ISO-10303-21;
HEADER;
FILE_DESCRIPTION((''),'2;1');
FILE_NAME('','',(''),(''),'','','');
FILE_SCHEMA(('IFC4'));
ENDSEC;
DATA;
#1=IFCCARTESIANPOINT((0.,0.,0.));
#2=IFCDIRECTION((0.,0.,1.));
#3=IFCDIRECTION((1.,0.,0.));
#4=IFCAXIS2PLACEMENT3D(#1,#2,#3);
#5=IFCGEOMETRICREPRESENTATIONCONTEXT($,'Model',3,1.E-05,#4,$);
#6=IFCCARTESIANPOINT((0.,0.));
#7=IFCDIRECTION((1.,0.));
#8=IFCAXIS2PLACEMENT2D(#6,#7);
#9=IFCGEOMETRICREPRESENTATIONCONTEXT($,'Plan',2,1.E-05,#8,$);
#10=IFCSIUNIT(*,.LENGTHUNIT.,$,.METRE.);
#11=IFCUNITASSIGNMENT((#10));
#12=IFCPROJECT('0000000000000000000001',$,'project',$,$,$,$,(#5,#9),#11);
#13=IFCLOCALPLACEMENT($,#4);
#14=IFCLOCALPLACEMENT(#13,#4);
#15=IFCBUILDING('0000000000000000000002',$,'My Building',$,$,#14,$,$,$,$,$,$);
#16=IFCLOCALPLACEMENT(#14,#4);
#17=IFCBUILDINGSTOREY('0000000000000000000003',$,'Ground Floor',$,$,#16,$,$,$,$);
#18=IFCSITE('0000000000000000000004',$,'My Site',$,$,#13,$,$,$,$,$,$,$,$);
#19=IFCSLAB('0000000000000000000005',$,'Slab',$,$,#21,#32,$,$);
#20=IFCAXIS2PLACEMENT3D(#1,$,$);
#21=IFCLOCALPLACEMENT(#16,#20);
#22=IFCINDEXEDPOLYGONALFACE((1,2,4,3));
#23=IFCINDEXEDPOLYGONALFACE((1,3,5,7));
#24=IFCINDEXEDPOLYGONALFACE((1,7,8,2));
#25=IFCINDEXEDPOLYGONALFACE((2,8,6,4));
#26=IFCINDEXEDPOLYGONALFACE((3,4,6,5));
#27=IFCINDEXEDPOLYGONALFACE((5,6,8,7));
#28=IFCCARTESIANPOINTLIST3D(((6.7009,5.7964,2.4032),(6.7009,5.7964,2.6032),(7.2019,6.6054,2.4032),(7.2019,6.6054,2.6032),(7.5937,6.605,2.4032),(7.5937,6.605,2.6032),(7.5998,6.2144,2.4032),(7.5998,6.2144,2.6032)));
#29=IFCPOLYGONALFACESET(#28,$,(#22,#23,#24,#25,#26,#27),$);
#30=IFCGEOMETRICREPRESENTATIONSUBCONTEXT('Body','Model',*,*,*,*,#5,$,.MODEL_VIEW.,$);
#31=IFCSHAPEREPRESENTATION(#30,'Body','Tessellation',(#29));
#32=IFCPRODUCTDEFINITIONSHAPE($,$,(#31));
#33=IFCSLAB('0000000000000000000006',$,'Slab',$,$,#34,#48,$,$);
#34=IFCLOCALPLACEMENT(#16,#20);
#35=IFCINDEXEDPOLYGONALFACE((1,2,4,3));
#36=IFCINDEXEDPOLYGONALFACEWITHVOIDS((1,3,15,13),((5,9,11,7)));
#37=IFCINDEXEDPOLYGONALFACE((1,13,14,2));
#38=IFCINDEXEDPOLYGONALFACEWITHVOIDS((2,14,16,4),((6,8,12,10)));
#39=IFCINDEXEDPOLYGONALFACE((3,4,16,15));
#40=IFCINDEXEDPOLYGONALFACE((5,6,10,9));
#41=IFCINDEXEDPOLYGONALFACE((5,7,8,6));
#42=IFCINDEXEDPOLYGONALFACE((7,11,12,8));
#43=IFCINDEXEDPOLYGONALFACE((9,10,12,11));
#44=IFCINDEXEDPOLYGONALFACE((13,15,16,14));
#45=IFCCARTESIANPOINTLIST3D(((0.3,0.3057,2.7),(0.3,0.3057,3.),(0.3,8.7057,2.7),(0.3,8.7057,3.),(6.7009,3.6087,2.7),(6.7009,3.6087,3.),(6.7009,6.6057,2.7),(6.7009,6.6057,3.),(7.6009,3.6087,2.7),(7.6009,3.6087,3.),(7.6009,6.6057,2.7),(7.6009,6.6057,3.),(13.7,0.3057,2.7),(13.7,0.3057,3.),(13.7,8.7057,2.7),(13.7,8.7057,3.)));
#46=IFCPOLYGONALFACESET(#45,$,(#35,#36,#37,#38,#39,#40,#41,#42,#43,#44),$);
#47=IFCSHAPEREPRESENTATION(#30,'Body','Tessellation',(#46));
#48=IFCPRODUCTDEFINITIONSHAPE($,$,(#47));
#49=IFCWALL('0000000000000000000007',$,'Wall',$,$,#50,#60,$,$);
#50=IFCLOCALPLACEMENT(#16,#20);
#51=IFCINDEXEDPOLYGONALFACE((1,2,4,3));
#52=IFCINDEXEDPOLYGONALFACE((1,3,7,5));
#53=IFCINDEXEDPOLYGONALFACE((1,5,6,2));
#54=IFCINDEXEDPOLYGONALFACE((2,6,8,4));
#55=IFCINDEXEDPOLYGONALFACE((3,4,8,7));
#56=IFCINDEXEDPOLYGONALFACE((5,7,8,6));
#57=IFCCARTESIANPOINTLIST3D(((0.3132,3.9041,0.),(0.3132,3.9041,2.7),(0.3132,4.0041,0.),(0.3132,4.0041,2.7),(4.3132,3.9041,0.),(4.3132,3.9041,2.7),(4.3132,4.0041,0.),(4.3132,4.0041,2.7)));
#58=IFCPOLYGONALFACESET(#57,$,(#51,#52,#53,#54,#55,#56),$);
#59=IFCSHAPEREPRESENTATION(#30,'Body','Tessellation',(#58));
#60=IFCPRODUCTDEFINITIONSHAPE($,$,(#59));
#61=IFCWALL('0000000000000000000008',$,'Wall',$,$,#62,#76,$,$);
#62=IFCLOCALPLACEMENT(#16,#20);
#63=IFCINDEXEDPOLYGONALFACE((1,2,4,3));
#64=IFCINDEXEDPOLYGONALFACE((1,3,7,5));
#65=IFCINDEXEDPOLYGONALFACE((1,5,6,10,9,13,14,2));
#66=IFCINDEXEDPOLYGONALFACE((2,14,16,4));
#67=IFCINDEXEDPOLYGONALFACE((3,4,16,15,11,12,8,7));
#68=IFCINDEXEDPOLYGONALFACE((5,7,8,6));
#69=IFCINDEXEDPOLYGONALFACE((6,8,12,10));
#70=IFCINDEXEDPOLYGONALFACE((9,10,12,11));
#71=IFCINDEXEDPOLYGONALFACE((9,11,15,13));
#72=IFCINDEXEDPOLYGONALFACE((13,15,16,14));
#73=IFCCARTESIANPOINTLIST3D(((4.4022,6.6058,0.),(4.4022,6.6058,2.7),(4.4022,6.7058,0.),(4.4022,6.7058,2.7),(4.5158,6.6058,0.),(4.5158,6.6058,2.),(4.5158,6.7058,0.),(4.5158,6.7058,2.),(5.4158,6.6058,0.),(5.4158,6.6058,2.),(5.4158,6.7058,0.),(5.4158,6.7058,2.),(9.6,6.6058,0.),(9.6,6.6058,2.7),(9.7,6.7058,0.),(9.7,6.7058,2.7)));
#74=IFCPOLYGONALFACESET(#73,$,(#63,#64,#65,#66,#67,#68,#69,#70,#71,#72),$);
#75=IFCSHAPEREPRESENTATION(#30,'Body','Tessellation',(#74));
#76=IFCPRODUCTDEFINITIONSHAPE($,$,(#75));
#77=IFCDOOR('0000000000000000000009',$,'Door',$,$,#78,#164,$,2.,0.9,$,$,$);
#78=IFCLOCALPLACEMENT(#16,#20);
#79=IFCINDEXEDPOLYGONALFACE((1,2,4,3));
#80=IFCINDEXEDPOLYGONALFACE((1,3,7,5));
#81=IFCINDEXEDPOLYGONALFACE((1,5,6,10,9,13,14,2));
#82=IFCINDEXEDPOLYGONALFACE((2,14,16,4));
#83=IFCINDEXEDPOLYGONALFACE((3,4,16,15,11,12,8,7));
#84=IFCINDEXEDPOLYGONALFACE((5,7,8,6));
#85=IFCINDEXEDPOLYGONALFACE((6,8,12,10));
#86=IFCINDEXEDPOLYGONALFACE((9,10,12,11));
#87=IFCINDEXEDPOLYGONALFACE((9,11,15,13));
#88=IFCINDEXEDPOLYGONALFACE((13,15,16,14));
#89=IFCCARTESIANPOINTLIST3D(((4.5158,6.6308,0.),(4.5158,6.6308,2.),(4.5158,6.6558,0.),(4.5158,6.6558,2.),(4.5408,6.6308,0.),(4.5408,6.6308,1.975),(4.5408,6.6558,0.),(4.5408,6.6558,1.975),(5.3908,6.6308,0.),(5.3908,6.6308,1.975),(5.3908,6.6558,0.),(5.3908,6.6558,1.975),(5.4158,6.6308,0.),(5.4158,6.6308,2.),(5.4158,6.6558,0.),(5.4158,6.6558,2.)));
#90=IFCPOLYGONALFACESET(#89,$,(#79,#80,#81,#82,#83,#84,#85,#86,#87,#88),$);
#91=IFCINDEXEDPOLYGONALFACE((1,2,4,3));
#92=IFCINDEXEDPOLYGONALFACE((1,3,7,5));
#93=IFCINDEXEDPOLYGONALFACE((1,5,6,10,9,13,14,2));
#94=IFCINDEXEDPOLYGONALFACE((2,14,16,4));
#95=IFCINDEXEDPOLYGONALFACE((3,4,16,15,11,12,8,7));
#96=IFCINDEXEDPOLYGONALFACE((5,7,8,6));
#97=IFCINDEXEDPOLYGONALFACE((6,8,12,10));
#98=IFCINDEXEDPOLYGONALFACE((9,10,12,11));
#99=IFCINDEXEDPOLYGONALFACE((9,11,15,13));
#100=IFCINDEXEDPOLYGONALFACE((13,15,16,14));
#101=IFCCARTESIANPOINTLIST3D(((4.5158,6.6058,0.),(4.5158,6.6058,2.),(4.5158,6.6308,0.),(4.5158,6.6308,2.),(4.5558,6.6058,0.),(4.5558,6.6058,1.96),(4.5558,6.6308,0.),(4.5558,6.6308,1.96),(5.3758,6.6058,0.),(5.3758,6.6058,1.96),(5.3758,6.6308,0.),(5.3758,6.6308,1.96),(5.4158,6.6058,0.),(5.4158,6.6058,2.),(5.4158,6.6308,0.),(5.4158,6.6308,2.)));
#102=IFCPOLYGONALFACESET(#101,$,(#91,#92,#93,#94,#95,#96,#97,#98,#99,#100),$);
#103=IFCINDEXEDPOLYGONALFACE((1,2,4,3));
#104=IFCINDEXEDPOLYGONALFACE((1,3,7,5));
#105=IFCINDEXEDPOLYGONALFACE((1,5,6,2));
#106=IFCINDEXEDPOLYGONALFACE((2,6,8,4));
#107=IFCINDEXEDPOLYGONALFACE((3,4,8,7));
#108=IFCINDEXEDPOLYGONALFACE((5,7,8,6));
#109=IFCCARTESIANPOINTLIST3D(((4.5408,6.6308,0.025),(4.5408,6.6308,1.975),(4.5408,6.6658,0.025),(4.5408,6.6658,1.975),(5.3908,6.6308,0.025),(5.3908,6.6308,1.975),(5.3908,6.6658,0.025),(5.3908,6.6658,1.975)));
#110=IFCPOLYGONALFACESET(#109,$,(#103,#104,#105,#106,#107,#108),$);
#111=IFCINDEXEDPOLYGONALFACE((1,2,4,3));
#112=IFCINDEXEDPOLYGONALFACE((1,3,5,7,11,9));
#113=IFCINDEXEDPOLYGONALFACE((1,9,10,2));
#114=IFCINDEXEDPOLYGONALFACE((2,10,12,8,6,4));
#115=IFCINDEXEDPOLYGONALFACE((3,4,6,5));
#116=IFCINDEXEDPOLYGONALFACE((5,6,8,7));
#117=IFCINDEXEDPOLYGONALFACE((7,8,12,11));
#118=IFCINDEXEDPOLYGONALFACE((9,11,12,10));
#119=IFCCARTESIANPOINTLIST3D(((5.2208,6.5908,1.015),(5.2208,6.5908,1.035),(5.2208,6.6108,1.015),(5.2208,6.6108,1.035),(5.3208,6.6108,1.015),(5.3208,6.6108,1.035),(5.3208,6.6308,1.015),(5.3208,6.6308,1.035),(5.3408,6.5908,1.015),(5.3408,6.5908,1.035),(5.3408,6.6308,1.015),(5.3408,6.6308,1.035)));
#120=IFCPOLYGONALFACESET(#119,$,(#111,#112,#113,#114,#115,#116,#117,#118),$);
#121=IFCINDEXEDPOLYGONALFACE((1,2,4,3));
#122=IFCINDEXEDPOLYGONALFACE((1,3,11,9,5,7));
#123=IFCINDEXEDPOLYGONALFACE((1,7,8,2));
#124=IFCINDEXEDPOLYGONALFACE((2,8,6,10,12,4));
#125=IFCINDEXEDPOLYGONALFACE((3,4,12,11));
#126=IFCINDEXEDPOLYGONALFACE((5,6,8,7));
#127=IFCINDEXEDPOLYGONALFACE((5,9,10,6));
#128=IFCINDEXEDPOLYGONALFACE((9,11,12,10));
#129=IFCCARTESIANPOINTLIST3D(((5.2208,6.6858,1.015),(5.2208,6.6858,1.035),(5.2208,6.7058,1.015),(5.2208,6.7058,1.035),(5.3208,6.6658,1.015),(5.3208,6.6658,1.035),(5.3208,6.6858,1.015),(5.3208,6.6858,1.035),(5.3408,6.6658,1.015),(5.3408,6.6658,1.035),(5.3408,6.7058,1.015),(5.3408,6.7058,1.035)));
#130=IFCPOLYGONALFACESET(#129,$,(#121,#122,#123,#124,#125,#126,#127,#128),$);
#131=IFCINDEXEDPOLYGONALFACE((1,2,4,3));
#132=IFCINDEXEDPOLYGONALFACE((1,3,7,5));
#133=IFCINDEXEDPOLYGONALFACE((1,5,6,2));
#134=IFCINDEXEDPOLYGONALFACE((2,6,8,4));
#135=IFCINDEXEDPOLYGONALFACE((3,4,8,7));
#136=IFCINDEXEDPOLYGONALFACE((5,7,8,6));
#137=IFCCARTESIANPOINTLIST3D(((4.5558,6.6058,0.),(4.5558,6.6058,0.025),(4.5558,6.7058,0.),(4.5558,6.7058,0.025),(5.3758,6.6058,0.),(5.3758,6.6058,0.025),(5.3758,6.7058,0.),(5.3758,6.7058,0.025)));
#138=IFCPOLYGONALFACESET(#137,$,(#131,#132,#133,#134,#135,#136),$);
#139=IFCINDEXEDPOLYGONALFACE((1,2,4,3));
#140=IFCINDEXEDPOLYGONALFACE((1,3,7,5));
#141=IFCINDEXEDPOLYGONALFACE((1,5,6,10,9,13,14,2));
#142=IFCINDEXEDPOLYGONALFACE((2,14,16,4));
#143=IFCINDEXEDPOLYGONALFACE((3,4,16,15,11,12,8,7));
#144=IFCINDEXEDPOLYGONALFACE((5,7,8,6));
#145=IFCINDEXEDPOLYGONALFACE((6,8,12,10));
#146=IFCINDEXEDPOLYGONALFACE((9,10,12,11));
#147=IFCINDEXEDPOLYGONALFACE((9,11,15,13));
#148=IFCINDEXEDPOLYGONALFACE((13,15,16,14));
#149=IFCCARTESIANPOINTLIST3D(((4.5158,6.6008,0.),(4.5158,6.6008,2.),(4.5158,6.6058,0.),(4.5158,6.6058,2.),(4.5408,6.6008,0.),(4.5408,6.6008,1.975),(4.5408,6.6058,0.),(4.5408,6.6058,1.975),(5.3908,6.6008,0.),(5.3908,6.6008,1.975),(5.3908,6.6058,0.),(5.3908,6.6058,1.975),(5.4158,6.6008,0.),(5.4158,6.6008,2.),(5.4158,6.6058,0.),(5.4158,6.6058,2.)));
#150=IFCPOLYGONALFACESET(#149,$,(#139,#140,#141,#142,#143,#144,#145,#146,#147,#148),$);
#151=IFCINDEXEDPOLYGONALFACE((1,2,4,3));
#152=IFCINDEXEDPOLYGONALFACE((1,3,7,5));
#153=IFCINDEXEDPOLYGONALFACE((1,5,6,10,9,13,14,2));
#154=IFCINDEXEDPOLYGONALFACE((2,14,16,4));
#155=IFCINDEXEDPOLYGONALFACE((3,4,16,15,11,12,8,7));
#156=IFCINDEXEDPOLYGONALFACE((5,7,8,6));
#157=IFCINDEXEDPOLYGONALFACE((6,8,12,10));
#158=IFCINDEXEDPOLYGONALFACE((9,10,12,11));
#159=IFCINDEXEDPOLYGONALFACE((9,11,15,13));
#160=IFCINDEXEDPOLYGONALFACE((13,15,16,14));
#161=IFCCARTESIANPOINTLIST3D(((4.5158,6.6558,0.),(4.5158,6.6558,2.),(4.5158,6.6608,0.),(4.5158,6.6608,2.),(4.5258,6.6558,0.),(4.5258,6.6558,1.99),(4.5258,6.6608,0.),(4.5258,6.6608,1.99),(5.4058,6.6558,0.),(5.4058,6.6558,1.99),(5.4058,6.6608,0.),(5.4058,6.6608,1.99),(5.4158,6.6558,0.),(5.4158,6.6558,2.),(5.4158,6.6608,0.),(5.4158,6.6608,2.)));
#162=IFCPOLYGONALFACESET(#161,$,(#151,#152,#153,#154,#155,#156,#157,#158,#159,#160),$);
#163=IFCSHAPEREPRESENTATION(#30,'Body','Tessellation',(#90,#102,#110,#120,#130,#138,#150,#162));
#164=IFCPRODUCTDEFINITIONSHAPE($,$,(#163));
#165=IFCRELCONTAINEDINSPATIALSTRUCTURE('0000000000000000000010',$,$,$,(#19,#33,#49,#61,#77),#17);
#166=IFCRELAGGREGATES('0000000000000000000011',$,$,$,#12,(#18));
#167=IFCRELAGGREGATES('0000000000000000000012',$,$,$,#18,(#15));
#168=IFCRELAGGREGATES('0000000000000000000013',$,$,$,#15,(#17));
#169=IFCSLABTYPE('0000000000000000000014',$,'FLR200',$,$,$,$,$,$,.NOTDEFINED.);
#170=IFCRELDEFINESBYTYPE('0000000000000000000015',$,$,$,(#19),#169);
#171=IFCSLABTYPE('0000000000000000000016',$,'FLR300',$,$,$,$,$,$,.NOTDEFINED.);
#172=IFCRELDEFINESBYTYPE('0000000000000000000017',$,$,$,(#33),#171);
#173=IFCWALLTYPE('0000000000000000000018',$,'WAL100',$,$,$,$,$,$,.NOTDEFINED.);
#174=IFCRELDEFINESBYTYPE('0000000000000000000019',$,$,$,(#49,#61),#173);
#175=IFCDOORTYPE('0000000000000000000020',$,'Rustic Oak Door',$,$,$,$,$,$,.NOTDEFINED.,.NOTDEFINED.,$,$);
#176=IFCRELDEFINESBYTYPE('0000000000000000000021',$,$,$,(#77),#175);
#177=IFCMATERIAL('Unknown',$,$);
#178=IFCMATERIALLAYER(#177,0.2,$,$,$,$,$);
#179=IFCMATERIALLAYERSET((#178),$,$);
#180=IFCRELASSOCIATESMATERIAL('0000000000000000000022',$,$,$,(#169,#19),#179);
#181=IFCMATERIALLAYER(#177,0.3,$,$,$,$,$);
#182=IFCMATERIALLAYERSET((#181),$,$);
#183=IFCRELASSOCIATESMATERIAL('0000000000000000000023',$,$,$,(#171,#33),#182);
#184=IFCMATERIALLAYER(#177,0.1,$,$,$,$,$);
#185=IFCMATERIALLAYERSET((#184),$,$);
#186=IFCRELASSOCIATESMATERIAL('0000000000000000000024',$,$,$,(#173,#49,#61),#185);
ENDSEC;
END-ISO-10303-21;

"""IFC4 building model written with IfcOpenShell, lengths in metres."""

from ifc_helpers import new_model, entity, si_unit, frame, origin_with_axes, origin_2d_with_axis, place, context, subcontext, project, spatial, line, indexed_curve, outline, extrude, shape, source, transform, mapped, material, layer, layer_set, layer_usage, type_object, type_shapes, element, fill, save


model = new_model("IFC4")

# Units and contexts
model_context = context("Model", 3, precision=1e-05, world=origin_with_axes())
plan_context = context("Plan", 2, precision=1e-05, world=origin_2d_with_axis())
body_context_1 = subcontext(model_context, "Body", "Model", "MODEL_VIEW")
body_context_2 = subcontext(plan_context, "Body", "Plan", "PLAN_VIEW")
ifc_project = project(units=[si_unit("LENGTHUNIT", "METRE")], contexts=[model_context, plan_context])

# Site, building, storey
site_placement = place(None, origin_with_axes())
site = spatial("IfcSite", under=ifc_project, at=site_placement, Name="My Site")
building_placement = place(site_placement, origin_with_axes())
building = spatial("IfcBuilding", under=site, at=building_placement, Name="My Building")
storey_placement = place(building_placement, origin_with_axes())
storey = spatial("IfcBuildingStorey", under=building, at=storey_placement, Name="Ground Floor")

# Slabs
ifc_material = material(Name="Unknown")
ifc_layer_1 = layer(ifc_material, 0.2)
ifc_layer_set_1 = layer_set([ifc_layer_1])
slab_type_1 = type_object("IfcSlabType", Name="FLR200", PredefinedType="NOTDEFINED", material=ifc_layer_set_1)
ifc_layer_usage_1 = layer_usage(ifc_layer_set_1, "AXIS3", "POSITIVE", -0.3)
slab_1_placement = place(storey_placement, frame((6.7009, 5.7964, 2.7032), z_axis=(0.0, 0.0, 1.0), x_axis=(1.0, 0.0, 0.0)))
element("IfcSlab", 1, at=slab_1_placement, inside=storey, type_object=slab_type_1, material=ifc_layer_usage_1, Name="Slab", context=body_context_1, shape_type="SweptSolid", body=[
    extrude(outline(indexed_curve([(0.0, 0.0), (0.899, 0.418), (0.8928, 0.8086), (0.501, 0.809), (0.0, 0.0)])), frame((0.0, 0.0, -0.3), z_axis=(0.0, 0.0, 1.0), x_axis=(1.0, 0.0, 0.0)), (0.0, 0.0, 1.0), 0.2),
])
ifc_layer_2 = layer(ifc_material, 0.3)
ifc_layer_set_2 = layer_set([ifc_layer_2])
ifc_layer_usage_2 = layer_usage(ifc_layer_set_2, "AXIS3", "POSITIVE", -0.2)
slab_type_2 = type_object("IfcSlabType", Name="FLR300", PredefinedType="NOTDEFINED", material=ifc_layer_set_2)
slab_2_placement = place(storey_placement, frame((0.3, 8.7057, 2.9), z_axis=(0.0, 0.0, 1.0), x_axis=(1.0, 0.0, 0.0)))
element("IfcSlab", 2, at=slab_2_placement, inside=storey, type_object=slab_type_2, material=ifc_layer_usage_2, Name="Slab", context=body_context_1, shape_type="SweptSolid", body=[
    extrude(outline(indexed_curve([(0.0, 0.0), (13.4, 0.0), (13.4, -8.4), (0.0, -8.4), (0.0, 0.0)]), holes=[indexed_curve([(6.4009, -5.0969), (7.3009, -5.0969), (7.3009, -2.1), (6.4009, -2.1), (6.4009, -5.0969)])]), frame((0.0, 0.0, -0.2), z_axis=(0.0, 0.0, 1.0), x_axis=(1.0, 0.0, 0.0)), (0.0, 0.0, 1.0), 0.3),
])

# Shared definitions
ifc_layer_3 = layer(ifc_material, 0.1)
ifc_layer_set_3 = layer_set([ifc_layer_3])
wall_type = type_object("IfcWallType", Name="WAL100", PredefinedType="NOTDEFINED", material=ifc_layer_set_3)

# Wall
ifc_layer_usage_3 = layer_usage(ifc_layer_set_3, "AXIS2", "POSITIVE", 0.0)
wall_1_placement = place(storey_placement, frame((4.3132, 4.0041, 0.0), z_axis=(0.0, 0.0, 1.0), x_axis=(-1.0, 0.0, 0.0)))
element("IfcWall", 3, at=wall_1_placement, inside=storey, type_object=wall_type, material=ifc_layer_usage_3, Name="Wall", context=body_context_1, shape_type="SweptSolid", body=[
    extrude(outline(indexed_curve([(0.0, 0.0), (0.0, 0.1), (4.0, 0.1), (4.0, 0.0)], segments=[line(1, 2, 3, 4, 1)])), origin_with_axes(), (0.0, 0.0, 1.0), 2.7),
])

# Wall, opening, door
ifc_layer_usage_4 = layer_usage(ifc_layer_set_3, "AXIS2", "POSITIVE", 0.0)
wall_2_placement = place(storey_placement, frame((4.4022, 6.6058, 0.0), z_axis=(0.0, 0.0, 1.0), x_axis=(1.0, 0.0, 0.0)))
wall_2 = element("IfcWall", 4, at=wall_2_placement, inside=storey, type_object=wall_type, material=ifc_layer_usage_4, Name="Wall", context=body_context_1, shape_type="SweptSolid", body=[
    extrude(outline(indexed_curve([(0.0, 0.0), (0.0, 0.1), (5.2978, 0.1), (5.1978, 0.0)], segments=[line(1, 2, 3, 4, 1)])), origin_with_axes(), (0.0, 0.0, 1.0), 2.7),
])
shared_shape_1 = source(origin_with_axes(), body_context_1, "Body", "SweptSolid", [
    extrude(outline(indexed_curve([(0.0, 0.0), (0.9, 0.0), (0.9, 2.0), (0.0, 2.0)], segments=[line(1, 2, 3, 4, 1)])), frame((0.0, -0.6, 0.0), z_axis=(0.0, -1.0, 0.0), x_axis=(1.0, 0.0, 0.0)), (0.0, 0.0, -1.0), 1.2),
])
opening_1_placement = place(wall_2_placement, frame((0.1136, 0.0, 0.0), z_axis=(0.0, 0.0, 1.0), x_axis=(1.0, 0.0, 0.0)))
opening_1 = element("IfcOpeningElement", 5, at=opening_1_placement, cuts=wall_2, PredefinedType="OPENING", context=body_context_1, shape_type="MappedRepresentation", body=[
    mapped(shared_shape_1, transform((0.0, 0.0, 0.0), x_axis=(1.0, 0.0, 0.0), y_axis=(0.0, 1.0, 0.0), z_axis=(0.0, 0.0, 1.0), scale=1.0)),
])
door_type_1 = type_object("IfcDoorType", Name="Rustic Oak Door", OperationType="NOTDEFINED", PredefinedType="NOTDEFINED")
shared_shape_2 = source(origin_with_axes(), body_context_1, "Body", "SweptSolid", [
    extrude(outline(indexed_curve([(0.0, 0.0), (0.0, 2.0), (0.9, 2.0), (0.9, 0.0), (0.875, 0.0), (0.875, 1.975), (0.025, 1.975), (0.025, 0.0)], segments=[line(1, 2, 3, 4, 5, 6, 7, 8, 1)])), frame((0.0, 0.025, 0.0), z_axis=(0.0, -1.0, 0.0), x_axis=(1.0, 0.0, 0.0)), (0.0, 0.0, -1.0), 0.025),
    extrude(outline(indexed_curve([(0.0, 0.0), (0.0, 2.0), (0.9, 2.0), (0.9, 0.0), (0.86, 0.0), (0.86, 1.96), (0.04, 1.96), (0.04, 0.0)], segments=[line(1, 2, 3, 4, 5, 6, 7, 8, 1)])), frame((0.0, 0.0, 0.0), z_axis=(0.0, -1.0, 0.0), x_axis=(1.0, 0.0, 0.0)), (0.0, 0.0, -1.0), 0.025),
    extrude(outline(indexed_curve([(0.0, 0.0), (0.85, 0.0), (0.85, 0.035), (0.0, 0.035)], segments=[line(1, 2, 3, 4, 1)])), frame((0.025, 0.025, 0.025), z_axis=(0.0, 0.0, 1.0), x_axis=(1.0, 0.0, 0.0)), (0.0, 0.0, 1.0), 1.95),
    extrude(outline(indexed_curve([(0.0, 0.0), (0.0, -0.04), (-0.12, -0.04), (-0.12, -0.02), (-0.02, -0.02), (-0.02, 0.0)], segments=[line(1, 2, 3, 4, 5, 6, 1)])), frame((0.825, 0.025, 1.015), z_axis=(0.0, 0.0, 1.0), x_axis=(1.0, 0.0, 0.0)), (0.0, 0.0, 1.0), 0.02),
    extrude(outline(indexed_curve([(0.0, 0.0), (0.0, 0.04), (-0.12, 0.04), (-0.12, 0.02), (-0.02, 0.02), (-0.02, 0.0)], segments=[line(1, 2, 3, 4, 5, 6, 1)])), frame((0.825, 0.06, 1.015), z_axis=(0.0, 0.0, 1.0), x_axis=(1.0, 0.0, 0.0)), (0.0, 0.0, 1.0), 0.02),
    extrude(outline(indexed_curve([(0.0, 0.0), (0.82, 0.0), (0.82, 0.1), (0.0, 0.1)], segments=[line(1, 2, 3, 4, 1)])), frame((0.04, 0.0, 0.0), z_axis=(0.0, 0.0, 1.0), x_axis=(1.0, 0.0, 0.0)), (0.0, 0.0, 1.0), 0.025),
    extrude(outline(indexed_curve([(0.0, 0.0), (0.0, 2.0), (0.9, 2.0), (0.9, 0.0), (0.875, 0.0), (0.875, 1.975), (0.025, 1.975), (0.025, 0.0)], segments=[line(1, 2, 3, 4, 5, 6, 7, 8, 1)])), frame((0.0, -0.005, 0.0), z_axis=(0.0, -1.0, 0.0), x_axis=(1.0, 0.0, 0.0)), (0.0, 0.0, -1.0), 0.005),
    extrude(outline(indexed_curve([(0.0, 0.0), (0.0, 2.0), (0.9, 2.0), (0.9, 0.0), (0.89, 0.0), (0.89, 1.99), (0.01, 1.99), (0.01, 0.0)], segments=[line(1, 2, 3, 4, 5, 6, 7, 8, 1)])), frame((0.0, 0.05, 0.0), z_axis=(0.0, -1.0, 0.0), x_axis=(1.0, 0.0, 0.0)), (0.0, 0.0, -1.0), 0.005),
])
shared_shape_3 = source(origin_with_axes(), body_context_2, "Body", "Curve2D", [
    entity("IfcIndexedPolyCurve", entity("IfcCartesianPointList2D", [[0.0, 0.0], [0.0, 0.05], [0.025, 0.05], [0.025, 0.025], [0.04, 0.025], [0.04, 0.0]]), [entity("IfcLineIndex", [1, 2, 3, 4, 5, 6, 1])]),
    entity("IfcIndexedPolyCurve", entity("IfcCartesianPointList2D", [[0.9, 0.0], [0.9, 0.05], [0.875, 0.05], [0.875, 0.025], [0.86, 0.025], [0.86, 0.0]]), [entity("IfcLineIndex", [1, 2, 3, 4, 5, 6, 1])]),
    entity("IfcTrimmedCurve", entity("IfcEllipse", entity("IfcAxis2Placement2D", entity("IfcCartesianPoint", [0.06, 0.05]), entity("IfcDirection", [1.0, 0.0])), 0.815, 0.85), [entity("IfcCartesianPoint", [0.875, 0.05])], [entity("IfcCartesianPoint", [0.06, 0.9])], True, "CARTESIAN"),
    entity("IfcIndexedPolyCurve", entity("IfcCartesianPointList2D", [[0.025, 0.05], [0.06, 0.05], [0.06, 0.9], [0.025, 0.9]]), [entity("IfcLineIndex", [1, 2, 3, 4, 1])]),
])
type_shapes(door_type_1, [shared_shape_2, shared_shape_3])
door_1_placement = place(opening_1_placement, frame((0.0, 0.0, 0.0), z_axis=(0.0, 0.0, 1.0), x_axis=(1.0, 0.0, 0.0)))
door_1 = element("IfcDoor", 6, at=door_1_placement, inside=storey, type_object=door_type_1, Name="Door", OverallHeight=2.0, OverallWidth=0.9, shapes=[
    shape(body_context_1, "Body", "MappedRepresentation", [mapped(shared_shape_2, transform((0.0, 0.0, 0.0), x_axis=(1.0, 0.0, 0.0), y_axis=(0.0, 1.0, 0.0), z_axis=(0.0, 0.0, 1.0), scale=1.0))]),
    shape(body_context_2, "Body", "MappedRepresentation", [mapped(shared_shape_3, transform((0.0, 0.0, 0.0), x_axis=(1.0, 0.0, 0.0), y_axis=(0.0, 1.0, 0.0), z_axis=(0.0, 0.0, 1.0), scale=1.0))]),
])
fill(opening_1, door_1)

save(model, "model.ifc")
